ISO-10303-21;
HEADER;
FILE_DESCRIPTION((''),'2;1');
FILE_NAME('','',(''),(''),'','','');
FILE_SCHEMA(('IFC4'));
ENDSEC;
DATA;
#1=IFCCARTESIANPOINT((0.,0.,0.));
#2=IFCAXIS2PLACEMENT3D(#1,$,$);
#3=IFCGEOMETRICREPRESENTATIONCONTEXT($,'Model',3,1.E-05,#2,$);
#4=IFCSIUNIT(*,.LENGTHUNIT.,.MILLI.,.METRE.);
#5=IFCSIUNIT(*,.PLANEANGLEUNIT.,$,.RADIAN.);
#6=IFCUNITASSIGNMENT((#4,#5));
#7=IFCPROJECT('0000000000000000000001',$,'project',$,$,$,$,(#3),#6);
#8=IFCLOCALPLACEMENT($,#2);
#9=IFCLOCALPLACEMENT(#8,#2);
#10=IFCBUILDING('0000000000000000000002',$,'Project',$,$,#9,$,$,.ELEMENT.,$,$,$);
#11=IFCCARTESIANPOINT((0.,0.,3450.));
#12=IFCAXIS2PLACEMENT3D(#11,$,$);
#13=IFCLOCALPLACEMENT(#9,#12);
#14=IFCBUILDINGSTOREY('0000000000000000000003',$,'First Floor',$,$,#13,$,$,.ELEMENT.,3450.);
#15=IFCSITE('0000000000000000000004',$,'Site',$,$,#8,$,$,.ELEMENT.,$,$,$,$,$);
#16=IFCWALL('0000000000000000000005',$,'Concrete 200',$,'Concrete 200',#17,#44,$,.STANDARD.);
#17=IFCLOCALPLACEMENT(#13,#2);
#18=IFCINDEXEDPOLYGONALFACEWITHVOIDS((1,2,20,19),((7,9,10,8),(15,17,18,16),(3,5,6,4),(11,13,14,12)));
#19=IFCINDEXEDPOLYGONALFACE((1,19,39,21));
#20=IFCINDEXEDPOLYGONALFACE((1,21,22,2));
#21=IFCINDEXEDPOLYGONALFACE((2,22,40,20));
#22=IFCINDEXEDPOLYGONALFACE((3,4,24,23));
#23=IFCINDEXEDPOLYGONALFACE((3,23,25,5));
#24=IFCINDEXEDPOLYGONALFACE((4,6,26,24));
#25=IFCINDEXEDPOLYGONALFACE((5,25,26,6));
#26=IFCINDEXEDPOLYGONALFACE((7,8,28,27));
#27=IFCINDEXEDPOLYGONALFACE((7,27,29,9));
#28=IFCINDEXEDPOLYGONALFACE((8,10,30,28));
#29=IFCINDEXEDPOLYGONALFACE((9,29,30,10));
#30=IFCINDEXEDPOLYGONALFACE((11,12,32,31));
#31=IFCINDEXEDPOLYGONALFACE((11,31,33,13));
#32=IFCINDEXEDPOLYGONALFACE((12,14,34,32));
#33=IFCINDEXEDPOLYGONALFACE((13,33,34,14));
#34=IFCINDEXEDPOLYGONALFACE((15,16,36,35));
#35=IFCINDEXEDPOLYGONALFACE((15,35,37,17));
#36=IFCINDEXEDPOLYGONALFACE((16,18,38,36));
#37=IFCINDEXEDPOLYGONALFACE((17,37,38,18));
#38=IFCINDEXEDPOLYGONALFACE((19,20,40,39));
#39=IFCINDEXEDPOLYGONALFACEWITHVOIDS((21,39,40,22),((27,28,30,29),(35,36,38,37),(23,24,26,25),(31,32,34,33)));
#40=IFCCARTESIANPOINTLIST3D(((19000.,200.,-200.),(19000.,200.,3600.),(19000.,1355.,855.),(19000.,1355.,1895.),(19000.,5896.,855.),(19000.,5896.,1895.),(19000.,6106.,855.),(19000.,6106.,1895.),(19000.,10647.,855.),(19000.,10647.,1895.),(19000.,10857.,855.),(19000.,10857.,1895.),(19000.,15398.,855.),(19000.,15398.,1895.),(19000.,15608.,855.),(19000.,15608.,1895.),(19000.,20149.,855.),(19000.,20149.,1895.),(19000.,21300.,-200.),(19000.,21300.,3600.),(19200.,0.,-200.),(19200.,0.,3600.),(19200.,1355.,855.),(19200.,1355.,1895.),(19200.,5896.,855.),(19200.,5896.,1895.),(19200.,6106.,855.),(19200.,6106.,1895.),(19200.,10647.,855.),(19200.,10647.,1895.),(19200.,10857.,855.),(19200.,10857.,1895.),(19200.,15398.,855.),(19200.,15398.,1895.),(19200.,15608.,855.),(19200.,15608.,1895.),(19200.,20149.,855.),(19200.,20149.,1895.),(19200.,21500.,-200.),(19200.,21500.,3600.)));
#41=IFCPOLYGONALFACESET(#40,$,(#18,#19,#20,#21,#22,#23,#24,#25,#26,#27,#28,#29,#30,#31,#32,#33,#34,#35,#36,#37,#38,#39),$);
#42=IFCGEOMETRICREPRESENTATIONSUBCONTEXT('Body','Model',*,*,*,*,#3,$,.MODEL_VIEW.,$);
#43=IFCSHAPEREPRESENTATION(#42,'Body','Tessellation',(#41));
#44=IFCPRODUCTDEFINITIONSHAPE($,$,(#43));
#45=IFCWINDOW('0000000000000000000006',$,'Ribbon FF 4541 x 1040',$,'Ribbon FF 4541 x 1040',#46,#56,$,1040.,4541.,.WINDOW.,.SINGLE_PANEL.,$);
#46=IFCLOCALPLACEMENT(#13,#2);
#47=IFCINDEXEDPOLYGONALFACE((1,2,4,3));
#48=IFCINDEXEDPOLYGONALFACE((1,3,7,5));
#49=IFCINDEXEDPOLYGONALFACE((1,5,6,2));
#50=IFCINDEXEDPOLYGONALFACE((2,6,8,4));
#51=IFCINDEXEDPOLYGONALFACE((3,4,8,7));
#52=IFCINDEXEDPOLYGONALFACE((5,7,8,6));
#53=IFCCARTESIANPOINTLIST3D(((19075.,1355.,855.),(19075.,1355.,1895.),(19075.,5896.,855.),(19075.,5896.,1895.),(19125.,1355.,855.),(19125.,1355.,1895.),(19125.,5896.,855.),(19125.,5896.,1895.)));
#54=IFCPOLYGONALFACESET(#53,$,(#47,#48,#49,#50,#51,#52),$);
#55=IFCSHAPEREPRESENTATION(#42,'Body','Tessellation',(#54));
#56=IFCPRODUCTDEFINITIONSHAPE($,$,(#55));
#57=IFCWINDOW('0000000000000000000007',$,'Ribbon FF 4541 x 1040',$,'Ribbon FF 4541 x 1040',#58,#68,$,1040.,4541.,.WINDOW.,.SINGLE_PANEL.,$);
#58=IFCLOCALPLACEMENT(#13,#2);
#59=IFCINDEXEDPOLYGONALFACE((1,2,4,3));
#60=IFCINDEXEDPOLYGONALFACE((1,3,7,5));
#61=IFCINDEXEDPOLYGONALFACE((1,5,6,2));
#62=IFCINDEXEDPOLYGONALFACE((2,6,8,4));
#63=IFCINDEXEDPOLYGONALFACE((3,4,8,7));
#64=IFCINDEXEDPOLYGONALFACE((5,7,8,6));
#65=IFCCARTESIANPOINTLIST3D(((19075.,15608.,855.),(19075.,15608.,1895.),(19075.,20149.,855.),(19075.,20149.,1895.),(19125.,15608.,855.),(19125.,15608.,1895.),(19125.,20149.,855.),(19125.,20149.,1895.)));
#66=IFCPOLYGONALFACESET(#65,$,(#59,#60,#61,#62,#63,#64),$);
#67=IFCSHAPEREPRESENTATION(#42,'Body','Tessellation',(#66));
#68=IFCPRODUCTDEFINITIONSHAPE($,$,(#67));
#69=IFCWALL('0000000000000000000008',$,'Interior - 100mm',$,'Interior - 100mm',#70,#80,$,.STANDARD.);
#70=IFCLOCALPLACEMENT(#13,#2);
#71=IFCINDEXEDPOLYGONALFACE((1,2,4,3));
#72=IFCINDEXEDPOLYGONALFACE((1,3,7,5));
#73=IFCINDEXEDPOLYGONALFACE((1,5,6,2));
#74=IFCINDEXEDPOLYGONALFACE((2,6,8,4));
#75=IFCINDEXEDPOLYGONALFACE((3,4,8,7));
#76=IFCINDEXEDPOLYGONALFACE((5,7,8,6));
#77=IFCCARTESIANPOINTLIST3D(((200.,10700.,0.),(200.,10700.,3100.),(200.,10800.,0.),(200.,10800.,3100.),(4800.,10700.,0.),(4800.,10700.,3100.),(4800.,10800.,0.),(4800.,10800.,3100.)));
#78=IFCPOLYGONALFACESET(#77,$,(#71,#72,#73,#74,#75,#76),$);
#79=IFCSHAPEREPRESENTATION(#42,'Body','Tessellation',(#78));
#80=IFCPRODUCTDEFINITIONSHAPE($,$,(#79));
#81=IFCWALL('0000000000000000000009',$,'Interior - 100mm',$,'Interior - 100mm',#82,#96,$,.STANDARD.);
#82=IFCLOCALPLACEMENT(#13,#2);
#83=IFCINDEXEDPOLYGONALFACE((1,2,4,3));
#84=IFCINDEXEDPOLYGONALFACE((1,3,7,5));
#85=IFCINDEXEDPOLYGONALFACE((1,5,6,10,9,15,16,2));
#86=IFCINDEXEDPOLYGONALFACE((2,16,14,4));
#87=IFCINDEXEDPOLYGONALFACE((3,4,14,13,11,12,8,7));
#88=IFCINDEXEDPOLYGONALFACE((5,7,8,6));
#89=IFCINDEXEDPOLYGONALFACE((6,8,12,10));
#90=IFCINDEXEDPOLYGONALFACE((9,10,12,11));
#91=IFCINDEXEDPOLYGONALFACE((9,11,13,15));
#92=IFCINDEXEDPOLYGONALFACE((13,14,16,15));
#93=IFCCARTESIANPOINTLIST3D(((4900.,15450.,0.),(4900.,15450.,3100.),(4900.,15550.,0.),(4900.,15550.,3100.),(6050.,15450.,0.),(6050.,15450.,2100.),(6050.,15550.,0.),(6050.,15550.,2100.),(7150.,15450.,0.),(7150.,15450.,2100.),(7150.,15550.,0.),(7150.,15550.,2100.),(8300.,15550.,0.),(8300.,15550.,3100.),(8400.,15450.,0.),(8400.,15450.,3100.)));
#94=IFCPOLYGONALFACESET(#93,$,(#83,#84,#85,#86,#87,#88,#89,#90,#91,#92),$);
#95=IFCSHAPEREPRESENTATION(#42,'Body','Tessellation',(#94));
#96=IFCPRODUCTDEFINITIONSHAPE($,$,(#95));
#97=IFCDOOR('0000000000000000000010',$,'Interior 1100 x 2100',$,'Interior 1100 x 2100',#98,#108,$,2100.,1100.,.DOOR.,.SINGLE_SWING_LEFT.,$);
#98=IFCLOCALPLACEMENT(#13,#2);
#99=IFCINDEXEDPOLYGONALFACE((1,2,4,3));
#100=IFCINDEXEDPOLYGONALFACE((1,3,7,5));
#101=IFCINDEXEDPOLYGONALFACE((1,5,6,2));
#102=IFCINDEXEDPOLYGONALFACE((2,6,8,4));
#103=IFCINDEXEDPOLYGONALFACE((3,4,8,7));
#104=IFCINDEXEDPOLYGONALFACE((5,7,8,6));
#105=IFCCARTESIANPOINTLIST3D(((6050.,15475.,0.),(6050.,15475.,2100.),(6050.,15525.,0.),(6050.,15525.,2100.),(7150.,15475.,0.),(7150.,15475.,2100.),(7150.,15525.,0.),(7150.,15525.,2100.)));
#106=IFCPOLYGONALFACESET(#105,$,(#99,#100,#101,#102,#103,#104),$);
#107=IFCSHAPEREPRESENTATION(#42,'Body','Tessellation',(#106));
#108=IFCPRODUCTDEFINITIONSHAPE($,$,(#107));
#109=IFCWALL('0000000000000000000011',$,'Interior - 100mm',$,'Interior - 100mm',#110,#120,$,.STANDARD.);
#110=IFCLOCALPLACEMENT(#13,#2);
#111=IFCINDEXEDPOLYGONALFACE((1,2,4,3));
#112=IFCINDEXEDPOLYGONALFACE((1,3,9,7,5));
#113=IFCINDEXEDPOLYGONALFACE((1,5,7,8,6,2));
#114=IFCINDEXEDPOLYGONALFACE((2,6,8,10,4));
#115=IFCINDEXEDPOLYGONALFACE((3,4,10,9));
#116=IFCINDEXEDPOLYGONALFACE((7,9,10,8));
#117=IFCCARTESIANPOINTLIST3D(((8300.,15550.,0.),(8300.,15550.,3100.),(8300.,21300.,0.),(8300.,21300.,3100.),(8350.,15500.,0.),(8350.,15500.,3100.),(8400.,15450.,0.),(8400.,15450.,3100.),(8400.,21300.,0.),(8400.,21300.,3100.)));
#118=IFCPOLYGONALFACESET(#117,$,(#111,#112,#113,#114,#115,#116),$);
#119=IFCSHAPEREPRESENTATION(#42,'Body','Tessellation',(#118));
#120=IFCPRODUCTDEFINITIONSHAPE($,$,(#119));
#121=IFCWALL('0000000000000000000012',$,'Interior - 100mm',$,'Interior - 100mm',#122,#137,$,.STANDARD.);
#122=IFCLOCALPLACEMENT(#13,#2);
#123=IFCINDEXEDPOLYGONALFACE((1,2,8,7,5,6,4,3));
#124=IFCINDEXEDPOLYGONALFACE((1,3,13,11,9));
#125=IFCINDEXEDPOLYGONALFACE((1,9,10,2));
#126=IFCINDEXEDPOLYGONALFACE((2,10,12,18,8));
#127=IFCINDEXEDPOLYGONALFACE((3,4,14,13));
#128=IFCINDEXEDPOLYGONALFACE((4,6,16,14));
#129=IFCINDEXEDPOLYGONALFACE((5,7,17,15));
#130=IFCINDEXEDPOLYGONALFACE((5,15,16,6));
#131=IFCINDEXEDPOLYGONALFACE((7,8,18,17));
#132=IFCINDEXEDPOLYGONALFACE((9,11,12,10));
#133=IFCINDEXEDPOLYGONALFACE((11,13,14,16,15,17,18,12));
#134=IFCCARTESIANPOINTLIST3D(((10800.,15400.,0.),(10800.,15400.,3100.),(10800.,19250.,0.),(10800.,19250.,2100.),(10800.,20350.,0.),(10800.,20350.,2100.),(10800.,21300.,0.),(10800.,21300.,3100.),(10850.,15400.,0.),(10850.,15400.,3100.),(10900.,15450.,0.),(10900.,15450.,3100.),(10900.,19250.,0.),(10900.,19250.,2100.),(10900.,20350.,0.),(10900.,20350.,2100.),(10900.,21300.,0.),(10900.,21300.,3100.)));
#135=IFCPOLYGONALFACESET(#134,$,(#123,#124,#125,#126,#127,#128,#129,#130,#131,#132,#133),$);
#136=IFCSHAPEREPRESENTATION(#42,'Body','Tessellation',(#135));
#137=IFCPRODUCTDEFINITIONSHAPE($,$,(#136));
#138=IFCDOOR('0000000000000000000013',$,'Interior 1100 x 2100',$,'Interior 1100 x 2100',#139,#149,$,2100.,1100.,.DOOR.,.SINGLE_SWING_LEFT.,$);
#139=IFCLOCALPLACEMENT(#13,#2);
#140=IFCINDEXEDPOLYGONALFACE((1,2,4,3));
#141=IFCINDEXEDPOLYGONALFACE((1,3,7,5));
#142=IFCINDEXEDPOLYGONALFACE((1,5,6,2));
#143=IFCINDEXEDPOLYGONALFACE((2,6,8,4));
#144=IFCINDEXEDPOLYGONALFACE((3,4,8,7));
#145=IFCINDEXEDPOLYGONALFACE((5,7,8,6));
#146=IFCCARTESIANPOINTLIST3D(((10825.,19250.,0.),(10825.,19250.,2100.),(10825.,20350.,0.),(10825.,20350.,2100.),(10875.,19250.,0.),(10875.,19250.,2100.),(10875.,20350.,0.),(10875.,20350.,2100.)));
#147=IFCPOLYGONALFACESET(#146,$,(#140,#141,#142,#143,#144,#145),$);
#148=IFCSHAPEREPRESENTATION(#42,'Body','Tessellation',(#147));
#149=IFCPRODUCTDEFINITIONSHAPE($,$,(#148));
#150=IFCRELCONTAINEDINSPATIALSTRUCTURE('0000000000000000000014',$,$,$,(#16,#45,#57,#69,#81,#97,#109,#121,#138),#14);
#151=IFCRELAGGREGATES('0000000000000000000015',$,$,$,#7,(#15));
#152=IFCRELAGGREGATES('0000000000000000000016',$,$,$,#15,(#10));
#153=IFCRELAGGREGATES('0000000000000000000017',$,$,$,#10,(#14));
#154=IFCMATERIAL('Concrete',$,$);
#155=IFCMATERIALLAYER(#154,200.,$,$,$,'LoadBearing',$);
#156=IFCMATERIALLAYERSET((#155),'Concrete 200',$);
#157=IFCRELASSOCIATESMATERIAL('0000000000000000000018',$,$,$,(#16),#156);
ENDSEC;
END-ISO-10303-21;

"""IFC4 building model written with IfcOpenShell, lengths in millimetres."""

from ifc_helpers import new_model, si_unit, frame, frame_2d, origin, place, context, subcontext, project, spatial, polyline, rectangle, outline, extrude, material, layer, layer_set, layer_usage, element, fill, save


model = new_model("IFC4")

# Units and contexts
model_context = context("Model", 3, precision=1e-05, world=origin())
body_context = subcontext(model_context, "Body", "Model", "MODEL_VIEW")
ifc_project = project(units=[si_unit("LENGTHUNIT", "METRE", prefix="MILLI"), si_unit("PLANEANGLEUNIT", "RADIAN")], contexts=[model_context])

# Site, building, storey
site_placement = place(None, origin())
site = spatial("IfcSite", under=ifc_project, at=site_placement, Name="Site", CompositionType="ELEMENT")
building_placement = place(site_placement, origin())
building = spatial("IfcBuilding", under=site, at=building_placement, Name="Project", CompositionType="ELEMENT")
storey_placement = place(building_placement, frame((0.0, 0.0, 3450.0)))
storey = spatial("IfcBuildingStorey", under=building, at=storey_placement, Name="First Floor", CompositionType="ELEMENT", Elevation=3450.0)

# Shared definitions
ifc_material = material(Name="Concrete")
ifc_layer = layer(ifc_material, 200.0, Category="LoadBearing")
ifc_layer_set = layer_set([ifc_layer], Name="Concrete 200")
ifc_layer_usage = layer_usage(ifc_layer_set, "AXIS2", "NEGATIVE", 100.0)

# Wall, openings, windows
wall_1_placement = place(storey_placement, frame((19100.0, 21400.0, -200.0), z_axis=(0.0, 0.0, 1.0), x_axis=(0.0, -1.0, 0.0)))
wall_1 = element("IfcWall", 1, at=wall_1_placement, inside=storey, material=ifc_layer_usage, Name="Concrete 200", ObjectType="Concrete 200", PredefinedType="STANDARD", context=body_context, shape_type="SweptSolid", body=[
    extrude(outline(polyline([(100.0, -100.0), (0.0, 0.0), (-100.0, 100.0), (21400.0, 100.0), (21300.0, 0.0), (21200.0, -100.0), (100.0, -100.0)])), origin(), (0.0, 0.0, 1.0), 3800.0),
])
opening_1_placement = place(wall_1_placement, frame((15504.0, 0.0, 1055.0), z_axis=(0.0, 0.0, 1.0), x_axis=(1.0, 0.0, 0.0)))
opening_1 = element("IfcOpeningElement", 2, at=opening_1_placement, cuts=wall_1, PredefinedType="OPENING", context=body_context, shape_type="SweptSolid", body=[
    extrude(rectangle(XDim=4541.0, YDim=220.0, at=frame_2d((2270.5, 0.0))), origin(), (0.0, 0.0, 1.0), 1040.0),
])
opening_2_placement = place(wall_1_placement, frame((10753.0, 0.0, 1055.0), z_axis=(0.0, 0.0, 1.0), x_axis=(1.0, 0.0, 0.0)))
element("IfcOpeningElement", 3, at=opening_2_placement, cuts=wall_1, PredefinedType="OPENING", context=body_context, shape_type="SweptSolid", body=[
    extrude(rectangle(XDim=4541.0, YDim=220.0, at=frame_2d((2270.5, 0.0))), origin(), (0.0, 0.0, 1.0), 1040.0),
])
opening_3_placement = place(wall_1_placement, frame((6002.0, 0.0, 1055.0), z_axis=(0.0, 0.0, 1.0), x_axis=(1.0, 0.0, 0.0)))
element("IfcOpeningElement", 4, at=opening_3_placement, cuts=wall_1, PredefinedType="OPENING", context=body_context, shape_type="SweptSolid", body=[
    extrude(rectangle(XDim=4541.0, YDim=220.0, at=frame_2d((2270.5, 0.0))), origin(), (0.0, 0.0, 1.0), 1040.0),
])
opening_4_placement = place(wall_1_placement, frame((1251.0, 0.0, 1055.0), z_axis=(0.0, 0.0, 1.0), x_axis=(1.0, 0.0, 0.0)))
opening_4 = element("IfcOpeningElement", 5, at=opening_4_placement, cuts=wall_1, PredefinedType="OPENING", context=body_context, shape_type="SweptSolid", body=[
    extrude(rectangle(XDim=4541.0, YDim=220.0, at=frame_2d((2270.5, 0.0))), origin(), (0.0, 0.0, 1.0), 1040.0),
])
window_1_placement = place(opening_1_placement, origin())
window_1 = element("IfcWindow", 6, at=window_1_placement, inside=storey, Name="Ribbon FF 4541 x 1040", ObjectType="Ribbon FF 4541 x 1040", OverallHeight=1040.0, OverallWidth=4541.0, PartitioningType="SINGLE_PANEL", PredefinedType="WINDOW", context=body_context, shape_type="SweptSolid", body=[
    extrude(rectangle(XDim=4541.0, YDim=50.0, at=frame_2d((2270.5, 0.0))), origin(), (0.0, 0.0, 1.0), 1040.0),
])
fill(opening_1, window_1)
window_2_placement = place(opening_4_placement, origin())
window_2 = element("IfcWindow", 7, at=window_2_placement, inside=storey, Name="Ribbon FF 4541 x 1040", ObjectType="Ribbon FF 4541 x 1040", OverallHeight=1040.0, OverallWidth=4541.0, PartitioningType="SINGLE_PANEL", PredefinedType="WINDOW", context=body_context, shape_type="SweptSolid", body=[
    extrude(rectangle(XDim=4541.0, YDim=50.0, at=frame_2d((2270.5, 0.0))), origin(), (0.0, 0.0, 1.0), 1040.0),
])
fill(opening_4, window_2)

# Wall
wall_2_placement = place(storey_placement, frame((200.0, 10750.0, 0.0), z_axis=(0.0, 0.0, 1.0), x_axis=(1.0, 0.0, 0.0)))
element("IfcWall", 8, at=wall_2_placement, inside=storey, Name="Interior - 100mm", ObjectType="Interior - 100mm", PredefinedType="STANDARD", context=body_context, shape_type="SweptSolid", body=[
    extrude(outline(polyline([(0.0, -50.0), (0.0, 50.0), (4600.0, 50.0), (4600.0, -50.0), (0.0, -50.0)])), origin(), (0.0, 0.0, 1.0), 3100.0),
])

# Wall, opening, door
wall_3_placement = place(storey_placement, frame((4850.0, 15500.0, 0.0), z_axis=(0.0, 0.0, 1.0), x_axis=(1.0, 0.0, 0.0)))
wall_3 = element("IfcWall", 9, at=wall_3_placement, inside=storey, Name="Interior - 100mm", ObjectType="Interior - 100mm", PredefinedType="STANDARD", context=body_context, shape_type="SweptSolid", body=[
    extrude(outline(polyline([(50.0, -50.0), (50.0, 50.0), (3450.0, 50.0), (3500.0, 0.0), (3550.0, -50.0), (50.0, -50.0)])), origin(), (0.0, 0.0, 1.0), 3100.0),
])
opening_5_placement = place(wall_3_placement, frame((1200.0, 0.0, 0.0), z_axis=(0.0, 0.0, 1.0), x_axis=(1.0, 0.0, 0.0)))
opening_5 = element("IfcOpeningElement", 10, at=opening_5_placement, cuts=wall_3, PredefinedType="OPENING", context=body_context, shape_type="SweptSolid", body=[
    extrude(rectangle(XDim=1100.0, YDim=120.0, at=frame_2d((550.0, 0.0))), origin(), (0.0, 0.0, 1.0), 2100.0),
])
door_1_placement = place(opening_5_placement, origin())
door_1 = element("IfcDoor", 11, at=door_1_placement, inside=storey, Name="Interior 1100 x 2100", ObjectType="Interior 1100 x 2100", OperationType="SINGLE_SWING_LEFT", OverallHeight=2100.0, OverallWidth=1100.0, PredefinedType="DOOR", context=body_context, shape_type="SweptSolid", body=[
    extrude(rectangle(XDim=1100.0, YDim=50.0, at=frame_2d((550.0, 0.0))), origin(), (0.0, 0.0, 1.0), 2100.0),
])
fill(opening_5, door_1)

# Wall
wall_4_placement = place(storey_placement, frame((8350.0, 15500.0, 0.0), z_axis=(0.0, 0.0, 1.0), x_axis=(0.0, 1.0, 0.0)))
element("IfcWall", 12, at=wall_4_placement, inside=storey, Name="Interior - 100mm", ObjectType="Interior - 100mm", PredefinedType="STANDARD", context=body_context, shape_type="SweptSolid", body=[
    extrude(outline(polyline([(-50.0, -50.0), (0.0, 0.0), (50.0, 50.0), (5800.0, 50.0), (5800.0, -50.0), (-50.0, -50.0)])), origin(), (0.0, 0.0, 1.0), 3100.0),
])

# Wall, opening, door
wall_5_placement = place(storey_placement, frame((10850.0, 15400.0, 0.0), z_axis=(0.0, 0.0, 1.0), x_axis=(0.0, 1.0, 0.0)))
wall_5 = element("IfcWall", 13, at=wall_5_placement, inside=storey, Name="Interior - 100mm", ObjectType="Interior - 100mm", PredefinedType="STANDARD", context=body_context, shape_type="SweptSolid", body=[
    extrude(outline(polyline([(50.0, -50.0), (0.0, 0.0), (0.0, 50.0), (5900.0, 50.0), (5900.0, -50.0), (50.0, -50.0)])), origin(), (0.0, 0.0, 1.0), 3100.0),
])
opening_6_placement = place(wall_5_placement, frame((3850.0, 0.0, 0.0), z_axis=(0.0, 0.0, 1.0), x_axis=(1.0, 0.0, 0.0)))
opening_6 = element("IfcOpeningElement", 14, at=opening_6_placement, cuts=wall_5, PredefinedType="OPENING", context=body_context, shape_type="SweptSolid", body=[
    extrude(rectangle(XDim=1100.0, YDim=120.0, at=frame_2d((550.0, 0.0))), origin(), (0.0, 0.0, 1.0), 2100.0),
])
door_2_placement = place(opening_6_placement, origin())
door_2 = element("IfcDoor", 15, at=door_2_placement, inside=storey, Name="Interior 1100 x 2100", ObjectType="Interior 1100 x 2100", OperationType="SINGLE_SWING_LEFT", OverallHeight=2100.0, OverallWidth=1100.0, PredefinedType="DOOR", context=body_context, shape_type="SweptSolid", body=[
    extrude(rectangle(XDim=1100.0, YDim=50.0, at=frame_2d((550.0, 0.0))), origin(), (0.0, 0.0, 1.0), 2100.0),
])
fill(opening_6, door_2)

save(model, "model.ifc")
